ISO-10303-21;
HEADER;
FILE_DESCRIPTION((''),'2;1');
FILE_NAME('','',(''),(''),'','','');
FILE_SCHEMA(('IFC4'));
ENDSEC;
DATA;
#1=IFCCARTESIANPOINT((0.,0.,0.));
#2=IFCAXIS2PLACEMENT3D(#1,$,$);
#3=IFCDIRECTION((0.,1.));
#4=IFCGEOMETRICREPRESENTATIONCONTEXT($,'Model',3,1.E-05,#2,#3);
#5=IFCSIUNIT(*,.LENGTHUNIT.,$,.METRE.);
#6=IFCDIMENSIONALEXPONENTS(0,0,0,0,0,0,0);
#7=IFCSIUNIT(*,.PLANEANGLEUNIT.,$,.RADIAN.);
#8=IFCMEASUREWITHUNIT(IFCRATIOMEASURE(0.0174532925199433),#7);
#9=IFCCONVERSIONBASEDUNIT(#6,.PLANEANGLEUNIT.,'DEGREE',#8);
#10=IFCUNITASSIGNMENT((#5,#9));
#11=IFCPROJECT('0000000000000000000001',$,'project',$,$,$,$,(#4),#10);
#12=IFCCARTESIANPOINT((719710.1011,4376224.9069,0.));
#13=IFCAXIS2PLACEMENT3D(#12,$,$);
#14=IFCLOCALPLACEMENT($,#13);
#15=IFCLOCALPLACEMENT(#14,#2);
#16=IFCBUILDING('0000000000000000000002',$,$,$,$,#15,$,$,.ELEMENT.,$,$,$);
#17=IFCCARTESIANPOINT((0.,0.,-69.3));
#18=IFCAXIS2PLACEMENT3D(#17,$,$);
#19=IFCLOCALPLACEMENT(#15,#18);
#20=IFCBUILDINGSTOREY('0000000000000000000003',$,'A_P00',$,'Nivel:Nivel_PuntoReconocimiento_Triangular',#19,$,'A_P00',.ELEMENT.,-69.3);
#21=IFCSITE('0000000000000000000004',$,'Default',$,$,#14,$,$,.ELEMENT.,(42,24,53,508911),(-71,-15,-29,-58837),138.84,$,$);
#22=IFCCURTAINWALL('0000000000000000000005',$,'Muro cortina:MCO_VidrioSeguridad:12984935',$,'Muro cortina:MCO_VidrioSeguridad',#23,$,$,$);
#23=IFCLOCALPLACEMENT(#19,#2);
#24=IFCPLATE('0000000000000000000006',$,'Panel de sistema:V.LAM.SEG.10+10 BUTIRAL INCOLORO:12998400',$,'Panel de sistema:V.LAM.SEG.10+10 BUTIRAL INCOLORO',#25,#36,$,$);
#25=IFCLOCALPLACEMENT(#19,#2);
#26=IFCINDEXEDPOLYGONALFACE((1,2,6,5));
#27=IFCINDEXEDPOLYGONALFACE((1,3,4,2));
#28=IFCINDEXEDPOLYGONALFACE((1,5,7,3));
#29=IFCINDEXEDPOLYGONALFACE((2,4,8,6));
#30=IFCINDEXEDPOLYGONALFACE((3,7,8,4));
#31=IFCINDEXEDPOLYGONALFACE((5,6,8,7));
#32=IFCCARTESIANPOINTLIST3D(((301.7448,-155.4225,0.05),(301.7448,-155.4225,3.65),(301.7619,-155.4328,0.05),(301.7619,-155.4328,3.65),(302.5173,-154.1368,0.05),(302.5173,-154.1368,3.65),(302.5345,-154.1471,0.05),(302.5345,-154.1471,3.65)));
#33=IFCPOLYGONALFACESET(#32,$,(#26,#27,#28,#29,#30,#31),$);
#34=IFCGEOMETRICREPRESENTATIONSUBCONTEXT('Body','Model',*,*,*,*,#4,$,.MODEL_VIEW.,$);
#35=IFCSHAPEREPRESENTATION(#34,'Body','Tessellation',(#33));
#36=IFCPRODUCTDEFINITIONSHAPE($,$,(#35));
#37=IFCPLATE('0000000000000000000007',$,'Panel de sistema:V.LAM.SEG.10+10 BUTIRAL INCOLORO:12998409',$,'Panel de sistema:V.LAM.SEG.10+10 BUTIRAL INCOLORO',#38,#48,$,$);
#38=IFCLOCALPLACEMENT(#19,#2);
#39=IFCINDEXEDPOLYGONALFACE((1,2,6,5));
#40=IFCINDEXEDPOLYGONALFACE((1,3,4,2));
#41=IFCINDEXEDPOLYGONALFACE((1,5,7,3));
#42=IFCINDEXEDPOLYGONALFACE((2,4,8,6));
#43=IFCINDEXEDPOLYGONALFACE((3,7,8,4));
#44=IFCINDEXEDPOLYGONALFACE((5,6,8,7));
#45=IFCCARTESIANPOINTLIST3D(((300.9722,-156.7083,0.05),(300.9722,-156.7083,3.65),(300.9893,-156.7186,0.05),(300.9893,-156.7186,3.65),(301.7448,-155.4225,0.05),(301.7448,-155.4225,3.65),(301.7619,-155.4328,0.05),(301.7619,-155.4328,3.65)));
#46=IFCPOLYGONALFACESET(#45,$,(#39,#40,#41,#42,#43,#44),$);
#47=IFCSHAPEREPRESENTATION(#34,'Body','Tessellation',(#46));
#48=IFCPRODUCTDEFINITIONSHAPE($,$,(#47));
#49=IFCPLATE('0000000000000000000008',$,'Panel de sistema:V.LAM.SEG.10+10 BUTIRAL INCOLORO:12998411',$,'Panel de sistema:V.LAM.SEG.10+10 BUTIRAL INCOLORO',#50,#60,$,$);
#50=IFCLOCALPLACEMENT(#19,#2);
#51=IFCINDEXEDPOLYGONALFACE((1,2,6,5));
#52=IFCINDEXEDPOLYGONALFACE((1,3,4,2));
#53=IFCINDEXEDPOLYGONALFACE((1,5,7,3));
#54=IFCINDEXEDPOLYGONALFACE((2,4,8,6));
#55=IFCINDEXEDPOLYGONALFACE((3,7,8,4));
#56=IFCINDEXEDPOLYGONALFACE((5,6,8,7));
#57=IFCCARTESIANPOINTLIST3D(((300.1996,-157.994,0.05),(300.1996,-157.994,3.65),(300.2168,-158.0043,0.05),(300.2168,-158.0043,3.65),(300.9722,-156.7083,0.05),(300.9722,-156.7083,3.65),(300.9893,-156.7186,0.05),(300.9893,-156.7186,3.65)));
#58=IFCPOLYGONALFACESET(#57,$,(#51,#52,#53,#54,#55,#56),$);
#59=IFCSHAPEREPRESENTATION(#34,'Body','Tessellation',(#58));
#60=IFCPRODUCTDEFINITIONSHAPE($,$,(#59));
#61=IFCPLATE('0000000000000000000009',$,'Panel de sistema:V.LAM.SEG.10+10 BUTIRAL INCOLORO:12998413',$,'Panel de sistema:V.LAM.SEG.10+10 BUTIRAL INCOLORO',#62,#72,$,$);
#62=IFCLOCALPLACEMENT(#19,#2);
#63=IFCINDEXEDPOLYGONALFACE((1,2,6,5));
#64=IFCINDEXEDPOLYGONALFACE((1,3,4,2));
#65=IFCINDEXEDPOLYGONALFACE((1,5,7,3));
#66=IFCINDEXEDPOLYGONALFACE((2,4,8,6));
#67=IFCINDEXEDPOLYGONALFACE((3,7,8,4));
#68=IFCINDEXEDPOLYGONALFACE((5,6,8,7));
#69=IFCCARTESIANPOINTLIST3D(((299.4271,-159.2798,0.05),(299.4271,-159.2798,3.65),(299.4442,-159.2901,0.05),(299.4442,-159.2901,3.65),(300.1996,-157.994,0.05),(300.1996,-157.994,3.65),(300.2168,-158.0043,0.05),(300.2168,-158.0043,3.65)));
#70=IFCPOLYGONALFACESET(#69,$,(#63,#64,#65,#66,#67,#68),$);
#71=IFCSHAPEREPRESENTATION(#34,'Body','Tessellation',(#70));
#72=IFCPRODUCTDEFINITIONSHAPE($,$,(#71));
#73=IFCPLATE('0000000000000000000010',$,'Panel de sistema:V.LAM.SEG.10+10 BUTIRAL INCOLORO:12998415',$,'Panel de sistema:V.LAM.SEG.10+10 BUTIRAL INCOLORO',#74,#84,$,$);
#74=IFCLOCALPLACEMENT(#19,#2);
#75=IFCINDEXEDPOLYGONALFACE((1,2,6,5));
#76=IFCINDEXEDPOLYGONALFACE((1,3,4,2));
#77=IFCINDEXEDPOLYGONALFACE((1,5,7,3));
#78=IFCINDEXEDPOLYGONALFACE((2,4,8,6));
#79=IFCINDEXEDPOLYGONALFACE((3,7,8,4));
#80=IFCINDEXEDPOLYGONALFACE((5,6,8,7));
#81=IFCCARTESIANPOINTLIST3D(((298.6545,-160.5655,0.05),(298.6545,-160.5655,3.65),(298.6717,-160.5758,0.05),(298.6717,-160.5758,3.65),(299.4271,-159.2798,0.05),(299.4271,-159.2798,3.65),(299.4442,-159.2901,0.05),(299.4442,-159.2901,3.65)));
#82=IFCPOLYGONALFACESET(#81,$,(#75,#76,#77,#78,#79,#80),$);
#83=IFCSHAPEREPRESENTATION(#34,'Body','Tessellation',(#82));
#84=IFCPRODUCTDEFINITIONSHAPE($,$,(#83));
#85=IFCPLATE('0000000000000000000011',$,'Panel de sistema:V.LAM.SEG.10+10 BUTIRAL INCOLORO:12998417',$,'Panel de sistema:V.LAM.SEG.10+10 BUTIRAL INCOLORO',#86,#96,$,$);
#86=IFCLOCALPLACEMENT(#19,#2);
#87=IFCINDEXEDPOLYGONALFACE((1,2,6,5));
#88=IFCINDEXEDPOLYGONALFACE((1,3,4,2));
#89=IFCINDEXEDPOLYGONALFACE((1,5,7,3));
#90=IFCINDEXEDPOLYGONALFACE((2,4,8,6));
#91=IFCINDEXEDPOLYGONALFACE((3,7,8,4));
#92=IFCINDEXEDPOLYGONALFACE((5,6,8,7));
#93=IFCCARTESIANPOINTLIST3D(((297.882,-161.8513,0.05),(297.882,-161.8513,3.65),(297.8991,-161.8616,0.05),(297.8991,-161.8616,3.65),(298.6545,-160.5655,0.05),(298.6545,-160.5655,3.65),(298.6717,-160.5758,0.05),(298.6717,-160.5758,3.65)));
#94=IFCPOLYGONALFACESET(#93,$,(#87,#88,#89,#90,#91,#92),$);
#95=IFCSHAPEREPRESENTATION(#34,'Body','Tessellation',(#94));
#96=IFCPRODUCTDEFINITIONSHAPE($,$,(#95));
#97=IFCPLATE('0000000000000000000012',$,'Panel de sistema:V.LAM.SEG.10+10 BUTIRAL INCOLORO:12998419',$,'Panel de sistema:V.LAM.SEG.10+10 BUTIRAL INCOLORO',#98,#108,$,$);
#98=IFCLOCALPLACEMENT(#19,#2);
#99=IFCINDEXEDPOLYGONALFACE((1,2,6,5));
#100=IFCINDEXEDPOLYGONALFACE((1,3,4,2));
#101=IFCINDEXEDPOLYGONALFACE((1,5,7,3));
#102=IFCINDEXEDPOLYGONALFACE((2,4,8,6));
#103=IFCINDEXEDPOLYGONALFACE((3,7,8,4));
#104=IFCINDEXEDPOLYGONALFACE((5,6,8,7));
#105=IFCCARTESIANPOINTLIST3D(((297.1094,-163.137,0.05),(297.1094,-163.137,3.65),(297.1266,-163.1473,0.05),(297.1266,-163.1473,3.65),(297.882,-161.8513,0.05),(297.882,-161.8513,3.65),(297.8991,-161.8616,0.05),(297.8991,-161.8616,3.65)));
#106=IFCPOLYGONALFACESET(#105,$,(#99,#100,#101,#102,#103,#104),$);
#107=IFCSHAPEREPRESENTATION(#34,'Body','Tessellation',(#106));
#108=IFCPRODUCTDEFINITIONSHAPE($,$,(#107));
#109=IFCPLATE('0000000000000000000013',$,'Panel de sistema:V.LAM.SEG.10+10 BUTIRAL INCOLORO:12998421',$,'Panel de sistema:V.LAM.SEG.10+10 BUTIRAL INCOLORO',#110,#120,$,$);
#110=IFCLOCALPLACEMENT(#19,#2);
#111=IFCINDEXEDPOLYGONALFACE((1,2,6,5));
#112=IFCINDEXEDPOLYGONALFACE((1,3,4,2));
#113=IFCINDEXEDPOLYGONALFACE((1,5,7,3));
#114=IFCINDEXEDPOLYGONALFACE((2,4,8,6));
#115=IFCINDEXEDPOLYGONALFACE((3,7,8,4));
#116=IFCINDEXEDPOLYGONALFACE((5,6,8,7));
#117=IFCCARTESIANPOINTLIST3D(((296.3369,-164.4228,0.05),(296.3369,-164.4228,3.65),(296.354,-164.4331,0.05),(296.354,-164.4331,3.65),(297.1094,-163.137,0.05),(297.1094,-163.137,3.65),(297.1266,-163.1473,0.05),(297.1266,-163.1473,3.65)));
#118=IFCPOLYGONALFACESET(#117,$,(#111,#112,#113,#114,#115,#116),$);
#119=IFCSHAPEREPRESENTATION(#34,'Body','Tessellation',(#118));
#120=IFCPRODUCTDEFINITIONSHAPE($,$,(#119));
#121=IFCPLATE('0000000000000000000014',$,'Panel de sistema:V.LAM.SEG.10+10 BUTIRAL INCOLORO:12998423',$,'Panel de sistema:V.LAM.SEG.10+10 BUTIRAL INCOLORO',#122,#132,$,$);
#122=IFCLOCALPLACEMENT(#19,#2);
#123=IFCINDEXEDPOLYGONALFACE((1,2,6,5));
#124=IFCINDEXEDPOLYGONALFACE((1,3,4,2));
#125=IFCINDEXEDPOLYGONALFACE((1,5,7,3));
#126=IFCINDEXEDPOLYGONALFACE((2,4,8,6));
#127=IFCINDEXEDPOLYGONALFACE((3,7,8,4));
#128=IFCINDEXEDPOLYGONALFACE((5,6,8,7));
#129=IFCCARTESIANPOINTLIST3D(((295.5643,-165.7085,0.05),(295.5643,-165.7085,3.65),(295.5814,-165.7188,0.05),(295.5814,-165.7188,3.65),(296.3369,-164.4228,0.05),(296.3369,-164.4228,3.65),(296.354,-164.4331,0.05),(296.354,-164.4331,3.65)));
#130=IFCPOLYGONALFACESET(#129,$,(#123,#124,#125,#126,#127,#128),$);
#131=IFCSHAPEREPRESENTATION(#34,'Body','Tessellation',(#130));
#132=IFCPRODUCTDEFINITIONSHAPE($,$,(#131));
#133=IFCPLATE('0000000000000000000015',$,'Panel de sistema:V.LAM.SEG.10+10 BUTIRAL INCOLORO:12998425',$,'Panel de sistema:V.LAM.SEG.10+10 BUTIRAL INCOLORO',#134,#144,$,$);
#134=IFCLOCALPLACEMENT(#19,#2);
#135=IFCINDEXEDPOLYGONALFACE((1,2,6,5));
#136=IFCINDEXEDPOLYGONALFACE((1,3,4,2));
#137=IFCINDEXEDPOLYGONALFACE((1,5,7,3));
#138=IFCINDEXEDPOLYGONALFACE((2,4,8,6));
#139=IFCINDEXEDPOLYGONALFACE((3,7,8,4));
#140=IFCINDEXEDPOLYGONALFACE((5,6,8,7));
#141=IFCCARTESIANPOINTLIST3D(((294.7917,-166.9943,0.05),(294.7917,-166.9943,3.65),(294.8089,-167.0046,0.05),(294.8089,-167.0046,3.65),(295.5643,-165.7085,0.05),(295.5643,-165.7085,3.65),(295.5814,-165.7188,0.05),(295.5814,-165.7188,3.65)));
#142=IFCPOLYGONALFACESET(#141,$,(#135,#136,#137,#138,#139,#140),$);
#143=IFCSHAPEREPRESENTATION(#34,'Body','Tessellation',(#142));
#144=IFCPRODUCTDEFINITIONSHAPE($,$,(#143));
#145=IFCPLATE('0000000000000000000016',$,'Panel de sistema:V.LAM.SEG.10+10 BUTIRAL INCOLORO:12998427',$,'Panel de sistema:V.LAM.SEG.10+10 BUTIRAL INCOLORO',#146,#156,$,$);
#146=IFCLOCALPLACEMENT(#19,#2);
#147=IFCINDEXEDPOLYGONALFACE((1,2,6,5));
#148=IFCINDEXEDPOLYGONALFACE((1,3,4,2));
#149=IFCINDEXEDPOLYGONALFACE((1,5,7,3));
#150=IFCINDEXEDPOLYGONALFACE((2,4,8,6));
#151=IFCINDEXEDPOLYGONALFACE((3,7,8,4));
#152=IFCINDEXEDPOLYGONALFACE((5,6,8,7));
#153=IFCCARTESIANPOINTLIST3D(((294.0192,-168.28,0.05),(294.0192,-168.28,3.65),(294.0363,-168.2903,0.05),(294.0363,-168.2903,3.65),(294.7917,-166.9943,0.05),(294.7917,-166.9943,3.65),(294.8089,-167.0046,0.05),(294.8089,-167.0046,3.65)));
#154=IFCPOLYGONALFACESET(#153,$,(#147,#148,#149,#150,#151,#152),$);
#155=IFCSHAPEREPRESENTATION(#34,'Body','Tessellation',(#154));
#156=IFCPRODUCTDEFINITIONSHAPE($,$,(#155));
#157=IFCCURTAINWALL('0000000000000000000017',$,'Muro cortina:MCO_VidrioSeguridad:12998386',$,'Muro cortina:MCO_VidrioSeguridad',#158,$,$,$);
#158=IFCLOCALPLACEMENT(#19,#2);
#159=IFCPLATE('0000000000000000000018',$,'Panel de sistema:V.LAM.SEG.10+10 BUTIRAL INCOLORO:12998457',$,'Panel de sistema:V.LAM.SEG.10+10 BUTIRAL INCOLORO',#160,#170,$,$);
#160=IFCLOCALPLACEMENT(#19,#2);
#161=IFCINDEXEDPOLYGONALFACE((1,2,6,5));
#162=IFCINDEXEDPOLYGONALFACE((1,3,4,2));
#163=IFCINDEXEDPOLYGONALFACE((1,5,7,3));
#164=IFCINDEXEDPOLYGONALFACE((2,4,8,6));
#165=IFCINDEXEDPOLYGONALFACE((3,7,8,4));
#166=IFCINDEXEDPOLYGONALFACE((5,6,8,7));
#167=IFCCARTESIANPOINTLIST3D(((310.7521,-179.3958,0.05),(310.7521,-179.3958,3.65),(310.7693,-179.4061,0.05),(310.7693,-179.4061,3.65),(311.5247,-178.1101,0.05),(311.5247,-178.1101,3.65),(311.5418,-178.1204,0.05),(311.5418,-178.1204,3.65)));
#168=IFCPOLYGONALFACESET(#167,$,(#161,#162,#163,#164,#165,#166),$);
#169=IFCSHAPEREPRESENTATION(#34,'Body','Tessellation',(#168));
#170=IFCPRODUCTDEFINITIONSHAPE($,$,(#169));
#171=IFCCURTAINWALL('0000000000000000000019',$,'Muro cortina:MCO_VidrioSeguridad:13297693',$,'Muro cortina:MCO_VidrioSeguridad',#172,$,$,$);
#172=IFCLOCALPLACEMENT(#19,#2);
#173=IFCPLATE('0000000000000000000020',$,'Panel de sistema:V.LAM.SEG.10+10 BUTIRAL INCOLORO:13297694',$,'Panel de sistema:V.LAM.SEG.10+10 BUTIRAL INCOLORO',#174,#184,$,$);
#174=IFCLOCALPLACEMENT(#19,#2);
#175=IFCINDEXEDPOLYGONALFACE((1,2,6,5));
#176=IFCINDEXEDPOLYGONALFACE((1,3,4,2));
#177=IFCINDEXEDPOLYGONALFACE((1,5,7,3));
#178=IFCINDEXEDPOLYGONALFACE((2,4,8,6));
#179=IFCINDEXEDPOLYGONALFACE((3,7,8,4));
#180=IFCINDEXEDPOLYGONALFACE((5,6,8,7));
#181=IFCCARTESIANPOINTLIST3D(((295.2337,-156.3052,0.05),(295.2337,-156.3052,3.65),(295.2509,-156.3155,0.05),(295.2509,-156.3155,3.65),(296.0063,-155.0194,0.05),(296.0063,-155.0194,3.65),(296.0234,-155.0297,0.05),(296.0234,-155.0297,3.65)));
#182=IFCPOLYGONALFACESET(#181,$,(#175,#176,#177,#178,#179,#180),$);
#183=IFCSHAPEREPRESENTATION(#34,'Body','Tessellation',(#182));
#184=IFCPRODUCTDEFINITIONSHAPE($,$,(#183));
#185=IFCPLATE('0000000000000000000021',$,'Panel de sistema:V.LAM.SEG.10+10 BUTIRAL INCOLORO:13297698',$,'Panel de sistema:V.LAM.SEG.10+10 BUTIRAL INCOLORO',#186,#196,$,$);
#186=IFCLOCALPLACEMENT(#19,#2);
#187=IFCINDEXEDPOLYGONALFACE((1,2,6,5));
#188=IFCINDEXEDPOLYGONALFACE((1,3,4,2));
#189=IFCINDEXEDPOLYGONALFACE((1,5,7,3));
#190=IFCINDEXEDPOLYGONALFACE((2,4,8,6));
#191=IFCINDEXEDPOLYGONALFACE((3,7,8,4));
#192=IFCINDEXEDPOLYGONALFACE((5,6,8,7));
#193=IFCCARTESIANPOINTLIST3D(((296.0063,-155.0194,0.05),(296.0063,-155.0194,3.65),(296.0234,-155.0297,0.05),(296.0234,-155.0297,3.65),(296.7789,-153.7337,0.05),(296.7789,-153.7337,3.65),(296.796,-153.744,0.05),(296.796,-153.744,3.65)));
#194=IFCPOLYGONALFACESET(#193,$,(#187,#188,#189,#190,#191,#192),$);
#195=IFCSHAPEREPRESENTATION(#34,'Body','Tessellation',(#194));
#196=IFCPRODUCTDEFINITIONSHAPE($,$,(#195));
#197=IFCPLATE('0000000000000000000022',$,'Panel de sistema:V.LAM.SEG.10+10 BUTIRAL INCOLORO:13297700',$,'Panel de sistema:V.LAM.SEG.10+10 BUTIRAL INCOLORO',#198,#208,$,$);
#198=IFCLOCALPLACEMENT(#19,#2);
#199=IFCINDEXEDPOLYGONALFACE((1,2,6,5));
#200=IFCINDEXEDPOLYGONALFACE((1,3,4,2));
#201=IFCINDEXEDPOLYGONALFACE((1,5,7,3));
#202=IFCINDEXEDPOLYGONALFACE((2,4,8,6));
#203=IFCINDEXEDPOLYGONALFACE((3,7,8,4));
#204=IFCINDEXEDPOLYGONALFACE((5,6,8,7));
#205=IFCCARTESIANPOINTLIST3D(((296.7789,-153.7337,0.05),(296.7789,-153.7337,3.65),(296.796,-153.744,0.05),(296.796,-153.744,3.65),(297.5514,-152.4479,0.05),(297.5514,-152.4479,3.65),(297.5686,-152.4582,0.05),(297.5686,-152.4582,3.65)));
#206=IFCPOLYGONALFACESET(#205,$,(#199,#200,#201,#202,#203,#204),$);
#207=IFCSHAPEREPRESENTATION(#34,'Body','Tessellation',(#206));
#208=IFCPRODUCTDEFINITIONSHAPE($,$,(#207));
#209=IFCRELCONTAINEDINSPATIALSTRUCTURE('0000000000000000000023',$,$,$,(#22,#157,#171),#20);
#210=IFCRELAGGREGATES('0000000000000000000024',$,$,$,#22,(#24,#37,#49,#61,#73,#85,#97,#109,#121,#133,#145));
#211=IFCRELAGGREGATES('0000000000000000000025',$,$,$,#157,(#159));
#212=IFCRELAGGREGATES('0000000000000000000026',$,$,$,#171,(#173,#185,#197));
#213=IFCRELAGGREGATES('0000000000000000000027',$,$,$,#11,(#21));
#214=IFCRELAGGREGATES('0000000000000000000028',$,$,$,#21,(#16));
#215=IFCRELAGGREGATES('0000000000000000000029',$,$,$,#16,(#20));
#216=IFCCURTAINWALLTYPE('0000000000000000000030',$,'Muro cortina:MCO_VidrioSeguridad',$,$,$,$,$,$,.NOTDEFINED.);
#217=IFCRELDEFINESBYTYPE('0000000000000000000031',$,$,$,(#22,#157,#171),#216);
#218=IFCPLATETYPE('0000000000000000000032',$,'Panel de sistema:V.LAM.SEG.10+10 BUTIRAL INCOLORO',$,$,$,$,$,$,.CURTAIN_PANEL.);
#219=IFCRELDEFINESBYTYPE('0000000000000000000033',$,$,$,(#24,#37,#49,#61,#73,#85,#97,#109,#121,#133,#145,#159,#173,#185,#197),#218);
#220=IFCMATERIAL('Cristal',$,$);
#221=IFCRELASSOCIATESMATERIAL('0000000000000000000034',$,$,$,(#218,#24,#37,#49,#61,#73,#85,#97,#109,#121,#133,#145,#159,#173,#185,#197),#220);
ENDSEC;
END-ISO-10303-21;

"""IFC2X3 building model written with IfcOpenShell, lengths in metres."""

from ifc_helpers import new_model, entity, si_unit, converted_unit, direction, frame, origin, origin_2d_with_axis, place, context, subcontext, project, spatial, rectangle, extrude, source, transform, mapped, material, type_object, type_shapes, element, aggregate, save


model = new_model("IFC2X3")

# Units and contexts
model_context = context("Model", 3, precision=1e-05, world=origin(), true_north=direction((0.0, 1.0)))
body_context = subcontext(model_context, "Body", "Model", "MODEL_VIEW")
ifc_project = project(units=[si_unit("LENGTHUNIT", "METRE"), converted_unit("PLANEANGLEUNIT", "DEGREE", entity("IfcRatioMeasure", 0.0174532925199433), si_unit("PLANEANGLEUNIT", "RADIAN"), dimensions=[0, 0, 0, 0, 0, 0, 0])], contexts=[model_context])

# Site, building, storey
site_placement = place(None, frame((719710.1011, 4376224.9069, 0.0)))
site = spatial("IfcSite", under=ifc_project, at=site_placement, Name="Default", CompositionType="ELEMENT", RefLatitude=(42, 24, 53, 508911), RefLongitude=(-71, -15, -29, -58837), RefElevation=138.84)
building_placement = place(site_placement, origin())
building = spatial("IfcBuilding", under=site, at=building_placement, CompositionType="ELEMENT")
storey_placement = place(building_placement, frame((0.0, 0.0, -69.3)))
storey = spatial("IfcBuildingStorey", under=building, at=storey_placement, Name="A_P00", ObjectType="Nivel:Nivel_PuntoReconocimiento_Triangular", LongName="A_P00", CompositionType="ELEMENT", Elevation=-69.3)

# Curtain wall, plates
curtain_wall_type = type_object("IfcCurtainWallType", Name="Muro cortina:MCO_VidrioSeguridad", PredefinedType="NOTDEFINED")
curtain_wall_1_placement = place(storey_placement, frame((0.0, 0.0, 69.3)))
curtain_wall_1 = element("IfcCurtainWall", 1, at=curtain_wall_1_placement, inside=storey, type_object=curtain_wall_type, Name="Muro cortina:MCO_VidrioSeguridad:12984935", ObjectType="Muro cortina:MCO_VidrioSeguridad")
ifc_material_1 = material(Name="Cristal")
plate_type_1 = type_object("IfcPlateType", Name="Panel de sistema:V.LAM.SEG.10+10 BUTIRAL INCOLORO", PredefinedType="CURTAIN_PANEL", material=ifc_material_1)
shared_shape_1 = source(origin(), body_context, "Body", "SweptSolid", [
    extrude(rectangle(XDim=0.02, YDim=1.5, at=origin_2d_with_axis()), frame((0.0, 0.0, 0.0), z_axis=(0.0, 0.0, 1.0), x_axis=(0.0, 1.0, 0.0)), (0.0, 0.0, 1.0), 3.6),
])
type_shapes(plate_type_1, [shared_shape_1])
plate_1_placement = place(curtain_wall_1_placement, frame((302.1396, -154.7848, -69.25), z_axis=(0.0, 0.0, 1.0), x_axis=(-0.515038, -0.857167, 0.0)))
plate_1 = element("IfcPlate", 2, at=plate_1_placement, type_object=plate_type_1, material=ifc_material_1, Name="Panel de sistema:V.LAM.SEG.10+10 BUTIRAL INCOLORO:12998400", ObjectType="Panel de sistema:V.LAM.SEG.10+10 BUTIRAL INCOLORO", context=body_context, shape_type="MappedRepresentation", body=[
    mapped(shared_shape_1, transform((0.0, 0.0, 0.0), scale=1.0)),
])
plate_2_placement = place(curtain_wall_1_placement, frame((301.3671, -156.0705, -69.25), z_axis=(0.0, 0.0, 1.0), x_axis=(-0.515038, -0.857167, 0.0)))
plate_2 = element("IfcPlate", 3, at=plate_2_placement, type_object=plate_type_1, material=ifc_material_1, Name="Panel de sistema:V.LAM.SEG.10+10 BUTIRAL INCOLORO:12998409", ObjectType="Panel de sistema:V.LAM.SEG.10+10 BUTIRAL INCOLORO", context=body_context, shape_type="MappedRepresentation", body=[
    mapped(shared_shape_1, transform((0.0, 0.0, 0.0), scale=1.0)),
])
plate_3_placement = place(curtain_wall_1_placement, frame((300.5945, -157.3563, -69.25), z_axis=(0.0, 0.0, 1.0), x_axis=(-0.515038, -0.857167, 0.0)))
plate_3 = element("IfcPlate", 4, at=plate_3_placement, type_object=plate_type_1, material=ifc_material_1, Name="Panel de sistema:V.LAM.SEG.10+10 BUTIRAL INCOLORO:12998411", ObjectType="Panel de sistema:V.LAM.SEG.10+10 BUTIRAL INCOLORO", context=body_context, shape_type="MappedRepresentation", body=[
    mapped(shared_shape_1, transform((0.0, 0.0, 0.0), scale=1.0)),
])
plate_4_placement = place(curtain_wall_1_placement, frame((299.8219, -158.642, -69.25), z_axis=(0.0, 0.0, 1.0), x_axis=(-0.515038, -0.857167, 0.0)))
plate_4 = element("IfcPlate", 5, at=plate_4_placement, type_object=plate_type_1, material=ifc_material_1, Name="Panel de sistema:V.LAM.SEG.10+10 BUTIRAL INCOLORO:12998413", ObjectType="Panel de sistema:V.LAM.SEG.10+10 BUTIRAL INCOLORO", context=body_context, shape_type="MappedRepresentation", body=[
    mapped(shared_shape_1, transform((0.0, 0.0, 0.0), scale=1.0)),
])
plate_5_placement = place(curtain_wall_1_placement, frame((299.0494, -159.9278, -69.25), z_axis=(0.0, 0.0, 1.0), x_axis=(-0.515038, -0.857167, 0.0)))
plate_5 = element("IfcPlate", 6, at=plate_5_placement, type_object=plate_type_1, material=ifc_material_1, Name="Panel de sistema:V.LAM.SEG.10+10 BUTIRAL INCOLORO:12998415", ObjectType="Panel de sistema:V.LAM.SEG.10+10 BUTIRAL INCOLORO", context=body_context, shape_type="MappedRepresentation", body=[
    mapped(shared_shape_1, transform((0.0, 0.0, 0.0), scale=1.0)),
])
plate_6_placement = place(curtain_wall_1_placement, frame((298.2768, -161.2135, -69.25), z_axis=(0.0, 0.0, 1.0), x_axis=(-0.515038, -0.857167, 0.0)))
plate_6 = element("IfcPlate", 7, at=plate_6_placement, type_object=plate_type_1, material=ifc_material_1, Name="Panel de sistema:V.LAM.SEG.10+10 BUTIRAL INCOLORO:12998417", ObjectType="Panel de sistema:V.LAM.SEG.10+10 BUTIRAL INCOLORO", context=body_context, shape_type="MappedRepresentation", body=[
    mapped(shared_shape_1, transform((0.0, 0.0, 0.0), scale=1.0)),
])
plate_7_placement = place(curtain_wall_1_placement, frame((297.5043, -162.4993, -69.25), z_axis=(0.0, 0.0, 1.0), x_axis=(-0.515038, -0.857167, 0.0)))
plate_7 = element("IfcPlate", 8, at=plate_7_placement, type_object=plate_type_1, material=ifc_material_1, Name="Panel de sistema:V.LAM.SEG.10+10 BUTIRAL INCOLORO:12998419", ObjectType="Panel de sistema:V.LAM.SEG.10+10 BUTIRAL INCOLORO", context=body_context, shape_type="MappedRepresentation", body=[
    mapped(shared_shape_1, transform((0.0, 0.0, 0.0), scale=1.0)),
])
plate_8_placement = place(curtain_wall_1_placement, frame((296.7317, -163.785, -69.25), z_axis=(0.0, 0.0, 1.0), x_axis=(-0.515038, -0.857167, 0.0)))
plate_8 = element("IfcPlate", 9, at=plate_8_placement, type_object=plate_type_1, material=ifc_material_1, Name="Panel de sistema:V.LAM.SEG.10+10 BUTIRAL INCOLORO:12998421", ObjectType="Panel de sistema:V.LAM.SEG.10+10 BUTIRAL INCOLORO", context=body_context, shape_type="MappedRepresentation", body=[
    mapped(shared_shape_1, transform((0.0, 0.0, 0.0), scale=1.0)),
])
plate_9_placement = place(curtain_wall_1_placement, frame((295.9592, -165.0708, -69.25), z_axis=(0.0, 0.0, 1.0), x_axis=(-0.515038, -0.857167, 0.0)))
plate_9 = element("IfcPlate", 10, at=plate_9_placement, type_object=plate_type_1, material=ifc_material_1, Name="Panel de sistema:V.LAM.SEG.10+10 BUTIRAL INCOLORO:12998423", ObjectType="Panel de sistema:V.LAM.SEG.10+10 BUTIRAL INCOLORO", context=body_context, shape_type="MappedRepresentation", body=[
    mapped(shared_shape_1, transform((0.0, 0.0, 0.0), scale=1.0)),
])
plate_10_placement = place(curtain_wall_1_placement, frame((295.1866, -166.3565, -69.25), z_axis=(0.0, 0.0, 1.0), x_axis=(-0.515038, -0.857167, 0.0)))
plate_10 = element("IfcPlate", 11, at=plate_10_placement, type_object=plate_type_1, material=ifc_material_1, Name="Panel de sistema:V.LAM.SEG.10+10 BUTIRAL INCOLORO:12998425", ObjectType="Panel de sistema:V.LAM.SEG.10+10 BUTIRAL INCOLORO", context=body_context, shape_type="MappedRepresentation", body=[
    mapped(shared_shape_1, transform((0.0, 0.0, 0.0), scale=1.0)),
])
plate_11_placement = place(curtain_wall_1_placement, frame((294.414, -167.6423, -69.25), z_axis=(0.0, 0.0, 1.0), x_axis=(-0.515038, -0.857167, 0.0)))
plate_11 = element("IfcPlate", 12, at=plate_11_placement, type_object=plate_type_1, material=ifc_material_1, Name="Panel de sistema:V.LAM.SEG.10+10 BUTIRAL INCOLORO:12998427", ObjectType="Panel de sistema:V.LAM.SEG.10+10 BUTIRAL INCOLORO", context=body_context, shape_type="MappedRepresentation", body=[
    mapped(shared_shape_1, transform((0.0, 0.0, 0.0), scale=1.0)),
])
aggregate(curtain_wall_1, [plate_1, plate_2, plate_3, plate_4, plate_5, plate_6, plate_7, plate_8, plate_9, plate_10, plate_11])

# Curtain wall, plate
curtain_wall_2_placement = place(storey_placement, frame((0.0, 0.0, 69.3)))
curtain_wall_2 = element("IfcCurtainWall", 13, at=curtain_wall_2_placement, inside=storey, type_object=curtain_wall_type, Name="Muro cortina:MCO_VidrioSeguridad:12998386", ObjectType="Muro cortina:MCO_VidrioSeguridad")
plate_12_placement = place(curtain_wall_2_placement, frame((311.147, -178.7581, -69.25), z_axis=(0.0, 0.0, 1.0), x_axis=(0.515038, 0.857167, 0.0)))
plate_12 = element("IfcPlate", 14, at=plate_12_placement, type_object=plate_type_1, material=ifc_material_1, Name="Panel de sistema:V.LAM.SEG.10+10 BUTIRAL INCOLORO:12998457", ObjectType="Panel de sistema:V.LAM.SEG.10+10 BUTIRAL INCOLORO", context=body_context, shape_type="MappedRepresentation", body=[
    mapped(shared_shape_1, transform((0.0, 0.0, 0.0), scale=1.0)),
])
aggregate(curtain_wall_2, [plate_12])

# Curtain wall, plates
curtain_wall_3_placement = place(storey_placement, frame((0.0, 0.0, 69.3)))
curtain_wall_3 = element("IfcCurtainWall", 15, at=curtain_wall_3_placement, inside=storey, type_object=curtain_wall_type, Name="Muro cortina:MCO_VidrioSeguridad:13297693", ObjectType="Muro cortina:MCO_VidrioSeguridad")
plate_13_placement = place(curtain_wall_3_placement, frame((295.6286, -155.6674, -69.25), z_axis=(0.0, 0.0, 1.0), x_axis=(0.515038, 0.857167, 0.0)))
plate_13 = element("IfcPlate", 16, at=plate_13_placement, type_object=plate_type_1, material=ifc_material_1, Name="Panel de sistema:V.LAM.SEG.10+10 BUTIRAL INCOLORO:13297694", ObjectType="Panel de sistema:V.LAM.SEG.10+10 BUTIRAL INCOLORO", context=body_context, shape_type="MappedRepresentation", body=[
    mapped(shared_shape_1, transform((0.0, 0.0, 0.0), scale=1.0)),
])
plate_14_placement = place(curtain_wall_3_placement, frame((296.4011, -154.3817, -69.25), z_axis=(0.0, 0.0, 1.0), x_axis=(0.515038, 0.857167, 0.0)))
plate_14 = element("IfcPlate", 17, at=plate_14_placement, type_object=plate_type_1, material=ifc_material_1, Name="Panel de sistema:V.LAM.SEG.10+10 BUTIRAL INCOLORO:13297698", ObjectType="Panel de sistema:V.LAM.SEG.10+10 BUTIRAL INCOLORO", context=body_context, shape_type="MappedRepresentation", body=[
    mapped(shared_shape_1, transform((0.0, 0.0, 0.0), scale=1.0)),
])
plate_15_placement = place(curtain_wall_3_placement, frame((297.1737, -153.0959, -69.25), z_axis=(0.0, 0.0, 1.0), x_axis=(0.515038, 0.857167, 0.0)))
plate_15 = element("IfcPlate", 18, at=plate_15_placement, type_object=plate_type_1, material=ifc_material_1, Name="Panel de sistema:V.LAM.SEG.10+10 BUTIRAL INCOLORO:13297700", ObjectType="Panel de sistema:V.LAM.SEG.10+10 BUTIRAL INCOLORO", context=body_context, shape_type="MappedRepresentation", body=[
    mapped(shared_shape_1, transform((0.0, 0.0, 0.0), scale=1.0)),
])
aggregate(curtain_wall_3, [plate_13, plate_14, plate_15])

save(model, "model.ifc")
